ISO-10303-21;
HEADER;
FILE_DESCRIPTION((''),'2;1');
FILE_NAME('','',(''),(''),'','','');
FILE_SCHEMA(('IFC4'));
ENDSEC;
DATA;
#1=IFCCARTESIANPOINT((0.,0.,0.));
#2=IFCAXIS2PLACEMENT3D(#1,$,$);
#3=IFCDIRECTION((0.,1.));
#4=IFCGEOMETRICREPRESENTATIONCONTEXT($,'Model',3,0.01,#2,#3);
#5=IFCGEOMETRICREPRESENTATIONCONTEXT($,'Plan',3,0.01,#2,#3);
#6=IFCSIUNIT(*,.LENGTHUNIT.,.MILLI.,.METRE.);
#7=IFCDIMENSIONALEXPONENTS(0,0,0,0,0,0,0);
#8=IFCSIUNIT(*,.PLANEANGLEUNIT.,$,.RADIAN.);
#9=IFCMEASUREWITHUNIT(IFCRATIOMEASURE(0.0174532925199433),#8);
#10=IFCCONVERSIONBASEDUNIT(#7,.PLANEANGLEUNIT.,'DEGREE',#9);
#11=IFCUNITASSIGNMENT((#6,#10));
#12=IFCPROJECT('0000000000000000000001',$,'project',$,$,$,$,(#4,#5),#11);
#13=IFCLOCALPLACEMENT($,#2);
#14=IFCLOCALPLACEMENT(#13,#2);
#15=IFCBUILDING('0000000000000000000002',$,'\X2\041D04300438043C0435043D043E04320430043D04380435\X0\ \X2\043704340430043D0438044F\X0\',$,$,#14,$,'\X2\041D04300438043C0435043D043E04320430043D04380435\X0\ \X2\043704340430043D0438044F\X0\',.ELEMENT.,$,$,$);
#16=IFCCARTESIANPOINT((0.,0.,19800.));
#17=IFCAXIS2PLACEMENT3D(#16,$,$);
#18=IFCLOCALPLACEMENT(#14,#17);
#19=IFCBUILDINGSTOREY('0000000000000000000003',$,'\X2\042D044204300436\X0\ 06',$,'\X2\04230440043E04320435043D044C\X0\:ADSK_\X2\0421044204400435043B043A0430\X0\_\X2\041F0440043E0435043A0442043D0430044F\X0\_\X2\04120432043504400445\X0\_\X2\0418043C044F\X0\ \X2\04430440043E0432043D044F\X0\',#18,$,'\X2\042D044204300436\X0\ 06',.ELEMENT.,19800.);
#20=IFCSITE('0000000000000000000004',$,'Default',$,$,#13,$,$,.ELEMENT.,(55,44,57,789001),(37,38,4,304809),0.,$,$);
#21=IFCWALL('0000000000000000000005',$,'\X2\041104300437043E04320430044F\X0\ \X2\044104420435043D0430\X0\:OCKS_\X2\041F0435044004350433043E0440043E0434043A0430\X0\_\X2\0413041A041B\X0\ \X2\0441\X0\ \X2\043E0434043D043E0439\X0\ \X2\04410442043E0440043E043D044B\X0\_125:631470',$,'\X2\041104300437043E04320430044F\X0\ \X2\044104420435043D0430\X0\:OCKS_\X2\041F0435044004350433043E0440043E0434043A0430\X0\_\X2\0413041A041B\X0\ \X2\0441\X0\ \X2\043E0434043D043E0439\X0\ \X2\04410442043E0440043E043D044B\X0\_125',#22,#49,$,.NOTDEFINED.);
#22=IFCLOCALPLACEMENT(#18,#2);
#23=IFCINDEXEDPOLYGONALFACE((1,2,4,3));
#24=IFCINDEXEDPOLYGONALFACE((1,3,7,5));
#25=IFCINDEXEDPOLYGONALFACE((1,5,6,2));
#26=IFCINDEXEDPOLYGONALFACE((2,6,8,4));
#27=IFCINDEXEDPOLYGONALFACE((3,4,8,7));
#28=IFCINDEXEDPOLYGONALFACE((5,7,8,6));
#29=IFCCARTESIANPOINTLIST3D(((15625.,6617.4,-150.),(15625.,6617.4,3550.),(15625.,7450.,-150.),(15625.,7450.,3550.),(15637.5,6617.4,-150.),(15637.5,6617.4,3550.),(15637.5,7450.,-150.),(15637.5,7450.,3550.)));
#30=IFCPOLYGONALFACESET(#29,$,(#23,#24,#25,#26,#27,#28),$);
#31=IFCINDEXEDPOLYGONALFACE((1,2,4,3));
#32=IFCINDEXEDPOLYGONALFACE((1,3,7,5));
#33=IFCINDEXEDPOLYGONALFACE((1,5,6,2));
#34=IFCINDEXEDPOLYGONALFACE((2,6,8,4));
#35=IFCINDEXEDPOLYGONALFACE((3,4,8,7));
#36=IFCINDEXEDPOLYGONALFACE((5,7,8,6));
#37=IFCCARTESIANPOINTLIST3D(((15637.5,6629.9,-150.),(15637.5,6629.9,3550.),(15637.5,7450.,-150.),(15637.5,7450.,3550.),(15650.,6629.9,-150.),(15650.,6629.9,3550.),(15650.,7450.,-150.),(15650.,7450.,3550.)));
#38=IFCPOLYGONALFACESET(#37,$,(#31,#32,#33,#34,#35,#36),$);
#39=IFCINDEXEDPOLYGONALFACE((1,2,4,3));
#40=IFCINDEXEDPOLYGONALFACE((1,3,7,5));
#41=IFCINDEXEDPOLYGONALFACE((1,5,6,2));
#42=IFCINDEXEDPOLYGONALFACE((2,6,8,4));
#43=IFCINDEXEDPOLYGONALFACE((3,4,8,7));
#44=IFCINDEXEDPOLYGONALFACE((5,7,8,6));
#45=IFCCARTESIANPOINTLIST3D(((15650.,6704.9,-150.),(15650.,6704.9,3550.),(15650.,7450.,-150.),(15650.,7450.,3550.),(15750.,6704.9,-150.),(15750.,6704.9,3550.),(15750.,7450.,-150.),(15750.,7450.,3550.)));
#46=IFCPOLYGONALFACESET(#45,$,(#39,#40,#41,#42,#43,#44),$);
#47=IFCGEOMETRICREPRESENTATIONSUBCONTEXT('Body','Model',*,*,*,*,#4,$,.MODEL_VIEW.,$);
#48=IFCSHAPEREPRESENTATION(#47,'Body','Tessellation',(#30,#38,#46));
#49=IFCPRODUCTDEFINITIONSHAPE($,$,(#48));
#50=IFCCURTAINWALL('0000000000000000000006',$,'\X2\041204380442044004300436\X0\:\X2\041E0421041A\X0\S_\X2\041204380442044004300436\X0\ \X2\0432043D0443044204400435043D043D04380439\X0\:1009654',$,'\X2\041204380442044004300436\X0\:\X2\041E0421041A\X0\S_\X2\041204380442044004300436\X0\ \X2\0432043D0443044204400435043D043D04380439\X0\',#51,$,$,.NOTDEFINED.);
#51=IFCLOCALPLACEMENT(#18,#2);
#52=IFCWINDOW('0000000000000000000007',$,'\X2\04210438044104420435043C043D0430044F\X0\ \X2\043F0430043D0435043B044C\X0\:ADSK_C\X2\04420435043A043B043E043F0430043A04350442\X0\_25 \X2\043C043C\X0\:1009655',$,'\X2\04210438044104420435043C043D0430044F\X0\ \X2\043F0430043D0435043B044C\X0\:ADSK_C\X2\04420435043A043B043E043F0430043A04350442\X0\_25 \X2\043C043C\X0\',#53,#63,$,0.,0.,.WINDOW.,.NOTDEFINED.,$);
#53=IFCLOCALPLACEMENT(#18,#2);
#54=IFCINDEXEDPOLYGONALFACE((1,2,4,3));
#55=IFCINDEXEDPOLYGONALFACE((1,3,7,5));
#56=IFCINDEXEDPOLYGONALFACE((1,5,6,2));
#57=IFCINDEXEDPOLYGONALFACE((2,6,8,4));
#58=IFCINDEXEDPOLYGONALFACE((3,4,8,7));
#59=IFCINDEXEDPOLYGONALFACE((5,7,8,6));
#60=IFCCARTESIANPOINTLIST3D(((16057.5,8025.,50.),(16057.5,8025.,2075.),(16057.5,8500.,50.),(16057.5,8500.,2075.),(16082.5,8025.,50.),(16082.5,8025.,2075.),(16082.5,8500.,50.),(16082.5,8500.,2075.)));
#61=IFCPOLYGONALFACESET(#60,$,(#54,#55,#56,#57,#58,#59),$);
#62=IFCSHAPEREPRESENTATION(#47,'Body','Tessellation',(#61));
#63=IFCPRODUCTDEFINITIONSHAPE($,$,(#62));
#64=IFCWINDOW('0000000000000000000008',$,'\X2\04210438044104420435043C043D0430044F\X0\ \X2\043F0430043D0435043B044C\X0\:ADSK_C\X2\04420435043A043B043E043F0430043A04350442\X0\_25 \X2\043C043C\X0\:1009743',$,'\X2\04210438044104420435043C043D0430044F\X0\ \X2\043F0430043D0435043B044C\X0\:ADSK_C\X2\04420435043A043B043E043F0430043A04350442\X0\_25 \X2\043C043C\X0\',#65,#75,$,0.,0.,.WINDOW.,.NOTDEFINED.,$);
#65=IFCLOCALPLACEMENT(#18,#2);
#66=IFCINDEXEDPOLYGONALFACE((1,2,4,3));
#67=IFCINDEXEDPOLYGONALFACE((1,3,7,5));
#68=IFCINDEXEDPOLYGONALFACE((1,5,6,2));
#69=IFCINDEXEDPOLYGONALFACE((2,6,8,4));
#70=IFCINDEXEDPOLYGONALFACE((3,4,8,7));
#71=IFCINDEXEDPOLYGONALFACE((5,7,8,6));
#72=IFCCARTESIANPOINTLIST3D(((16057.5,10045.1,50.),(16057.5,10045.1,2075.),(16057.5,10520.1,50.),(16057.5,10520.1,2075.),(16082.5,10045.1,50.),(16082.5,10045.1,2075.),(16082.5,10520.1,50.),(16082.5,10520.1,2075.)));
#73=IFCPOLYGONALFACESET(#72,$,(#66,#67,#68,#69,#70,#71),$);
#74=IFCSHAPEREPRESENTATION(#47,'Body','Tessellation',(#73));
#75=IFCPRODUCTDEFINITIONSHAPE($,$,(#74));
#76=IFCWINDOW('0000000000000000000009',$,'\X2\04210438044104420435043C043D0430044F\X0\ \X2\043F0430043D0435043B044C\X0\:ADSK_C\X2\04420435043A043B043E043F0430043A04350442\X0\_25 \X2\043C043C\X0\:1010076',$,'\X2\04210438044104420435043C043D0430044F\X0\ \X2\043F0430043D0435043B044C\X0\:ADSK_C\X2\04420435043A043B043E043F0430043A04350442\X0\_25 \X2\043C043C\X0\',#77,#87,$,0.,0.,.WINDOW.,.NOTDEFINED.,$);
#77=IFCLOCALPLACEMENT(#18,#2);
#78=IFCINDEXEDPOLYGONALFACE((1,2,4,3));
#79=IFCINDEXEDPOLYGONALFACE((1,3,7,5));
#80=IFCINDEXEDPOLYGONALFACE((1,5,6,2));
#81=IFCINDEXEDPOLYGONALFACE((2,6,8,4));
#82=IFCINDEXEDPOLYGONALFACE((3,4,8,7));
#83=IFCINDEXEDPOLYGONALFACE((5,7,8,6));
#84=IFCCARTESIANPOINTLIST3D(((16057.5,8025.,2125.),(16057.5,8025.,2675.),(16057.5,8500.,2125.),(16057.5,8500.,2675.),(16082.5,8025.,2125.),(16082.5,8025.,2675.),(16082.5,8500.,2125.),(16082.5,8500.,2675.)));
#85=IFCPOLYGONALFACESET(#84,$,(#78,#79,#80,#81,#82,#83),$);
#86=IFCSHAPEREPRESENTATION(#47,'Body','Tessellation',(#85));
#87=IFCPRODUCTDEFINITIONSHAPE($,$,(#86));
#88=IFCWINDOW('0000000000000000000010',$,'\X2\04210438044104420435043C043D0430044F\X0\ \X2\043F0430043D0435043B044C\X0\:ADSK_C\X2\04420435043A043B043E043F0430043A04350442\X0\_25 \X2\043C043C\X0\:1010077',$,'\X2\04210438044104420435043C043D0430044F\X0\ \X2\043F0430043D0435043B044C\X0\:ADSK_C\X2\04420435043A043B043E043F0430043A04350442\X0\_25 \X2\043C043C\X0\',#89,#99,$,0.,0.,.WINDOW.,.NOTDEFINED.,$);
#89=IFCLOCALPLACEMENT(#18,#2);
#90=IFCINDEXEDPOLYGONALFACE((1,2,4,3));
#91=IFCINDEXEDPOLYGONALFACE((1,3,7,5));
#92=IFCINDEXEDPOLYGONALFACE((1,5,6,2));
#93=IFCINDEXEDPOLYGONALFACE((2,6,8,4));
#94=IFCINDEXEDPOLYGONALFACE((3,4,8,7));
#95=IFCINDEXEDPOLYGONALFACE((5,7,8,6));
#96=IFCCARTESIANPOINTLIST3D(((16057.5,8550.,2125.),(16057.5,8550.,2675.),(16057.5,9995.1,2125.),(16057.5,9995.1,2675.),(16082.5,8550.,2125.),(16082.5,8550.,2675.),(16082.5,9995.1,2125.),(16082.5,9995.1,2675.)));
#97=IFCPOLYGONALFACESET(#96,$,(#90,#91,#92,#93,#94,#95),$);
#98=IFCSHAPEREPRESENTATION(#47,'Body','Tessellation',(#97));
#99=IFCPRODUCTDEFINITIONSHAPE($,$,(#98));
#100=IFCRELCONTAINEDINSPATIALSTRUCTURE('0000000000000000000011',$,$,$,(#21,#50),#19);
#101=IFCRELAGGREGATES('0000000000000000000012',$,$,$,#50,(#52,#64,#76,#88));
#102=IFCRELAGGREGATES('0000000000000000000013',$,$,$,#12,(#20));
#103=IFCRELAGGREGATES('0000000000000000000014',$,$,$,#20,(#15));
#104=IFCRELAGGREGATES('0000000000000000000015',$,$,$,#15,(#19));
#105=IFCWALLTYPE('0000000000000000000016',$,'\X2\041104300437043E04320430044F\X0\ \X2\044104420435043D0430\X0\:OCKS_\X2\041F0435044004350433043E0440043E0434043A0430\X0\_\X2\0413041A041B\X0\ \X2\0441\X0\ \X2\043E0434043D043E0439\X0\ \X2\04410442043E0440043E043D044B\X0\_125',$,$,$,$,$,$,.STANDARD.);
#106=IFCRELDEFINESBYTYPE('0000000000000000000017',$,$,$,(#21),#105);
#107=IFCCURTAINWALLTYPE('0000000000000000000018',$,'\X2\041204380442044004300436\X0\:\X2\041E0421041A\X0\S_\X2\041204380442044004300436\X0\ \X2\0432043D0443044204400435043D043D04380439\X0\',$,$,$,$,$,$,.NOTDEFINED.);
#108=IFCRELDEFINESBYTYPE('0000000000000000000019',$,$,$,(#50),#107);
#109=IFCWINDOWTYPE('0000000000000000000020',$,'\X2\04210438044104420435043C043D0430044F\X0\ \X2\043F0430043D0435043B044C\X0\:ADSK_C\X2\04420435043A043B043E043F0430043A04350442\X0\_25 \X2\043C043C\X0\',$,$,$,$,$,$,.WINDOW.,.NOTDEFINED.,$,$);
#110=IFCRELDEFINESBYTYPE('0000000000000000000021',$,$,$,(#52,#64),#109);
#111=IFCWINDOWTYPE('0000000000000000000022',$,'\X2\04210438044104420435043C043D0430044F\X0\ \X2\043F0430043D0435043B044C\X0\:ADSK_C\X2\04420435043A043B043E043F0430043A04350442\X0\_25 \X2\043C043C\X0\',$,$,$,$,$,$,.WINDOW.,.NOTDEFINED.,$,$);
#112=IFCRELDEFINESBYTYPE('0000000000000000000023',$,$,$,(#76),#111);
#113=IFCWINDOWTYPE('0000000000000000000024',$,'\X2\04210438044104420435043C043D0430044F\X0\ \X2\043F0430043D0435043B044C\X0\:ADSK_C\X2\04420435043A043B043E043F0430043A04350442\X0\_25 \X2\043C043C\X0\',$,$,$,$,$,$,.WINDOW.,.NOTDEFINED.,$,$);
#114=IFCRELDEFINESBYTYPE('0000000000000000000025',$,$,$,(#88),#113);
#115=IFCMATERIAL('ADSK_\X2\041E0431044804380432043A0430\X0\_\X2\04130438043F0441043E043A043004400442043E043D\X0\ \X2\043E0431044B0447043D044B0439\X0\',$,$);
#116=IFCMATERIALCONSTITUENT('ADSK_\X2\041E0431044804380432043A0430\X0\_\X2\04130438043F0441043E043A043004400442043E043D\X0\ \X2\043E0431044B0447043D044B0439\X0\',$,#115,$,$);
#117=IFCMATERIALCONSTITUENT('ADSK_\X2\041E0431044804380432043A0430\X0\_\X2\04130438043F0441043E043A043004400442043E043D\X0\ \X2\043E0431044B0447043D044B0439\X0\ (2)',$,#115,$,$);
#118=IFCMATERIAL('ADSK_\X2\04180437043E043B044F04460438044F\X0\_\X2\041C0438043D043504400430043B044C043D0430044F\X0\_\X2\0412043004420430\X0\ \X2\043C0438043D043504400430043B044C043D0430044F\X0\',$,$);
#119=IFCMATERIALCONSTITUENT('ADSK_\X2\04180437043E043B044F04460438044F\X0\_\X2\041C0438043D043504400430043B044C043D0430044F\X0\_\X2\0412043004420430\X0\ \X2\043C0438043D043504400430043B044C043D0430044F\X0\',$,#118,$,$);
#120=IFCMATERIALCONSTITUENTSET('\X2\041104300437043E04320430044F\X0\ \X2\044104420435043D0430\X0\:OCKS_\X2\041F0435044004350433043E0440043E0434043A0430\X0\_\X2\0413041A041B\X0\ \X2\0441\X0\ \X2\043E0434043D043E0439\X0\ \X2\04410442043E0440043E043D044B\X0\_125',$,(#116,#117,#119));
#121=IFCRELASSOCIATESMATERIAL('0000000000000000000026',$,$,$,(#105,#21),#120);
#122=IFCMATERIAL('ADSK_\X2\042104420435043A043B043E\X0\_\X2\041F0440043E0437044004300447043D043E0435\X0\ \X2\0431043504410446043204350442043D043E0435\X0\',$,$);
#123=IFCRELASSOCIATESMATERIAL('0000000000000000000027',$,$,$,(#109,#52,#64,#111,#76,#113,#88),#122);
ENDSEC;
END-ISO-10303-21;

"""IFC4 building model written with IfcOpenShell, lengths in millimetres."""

from ifc_helpers import new_model, entity, si_unit, converted_unit, direction, frame, origin, place, context, subcontext, project, spatial, indexed_curve, outline, extrude, source, transform, mapped, material, constituent, constituent_set, type_object, type_shapes, element, aggregate, save


model = new_model("IFC4")

# Units and contexts
model_context = context("Model", 3, precision=0.01, world=origin(), true_north=direction((0.0, 1.0)))
plan_context = context("Plan", 3, precision=0.01, world=origin(), true_north=direction((0.0, 1.0)))
body_context = subcontext(model_context, "Body", "Model", "MODEL_VIEW")
ifc_project = project(units=[si_unit("LENGTHUNIT", "METRE", prefix="MILLI"), converted_unit("PLANEANGLEUNIT", "DEGREE", entity("IfcRatioMeasure", 0.0174532925199433), si_unit("PLANEANGLEUNIT", "RADIAN"), dimensions=[0, 0, 0, 0, 0, 0, 0])], contexts=[model_context, plan_context])

# Site, building, storey
site_placement = place(None, frame((0.0, 0.0, 0.0)))
site = spatial("IfcSite", under=ifc_project, at=site_placement, Name="Default", CompositionType="ELEMENT", RefLatitude=(55, 44, 57, 789001), RefLongitude=(37, 38, 4, 304809), RefElevation=0.0)
building_placement = place(site_placement, origin())
building = spatial("IfcBuilding", under=site, at=building_placement, Name="Наименование здания", LongName="Наименование здания", CompositionType="ELEMENT")
storey_placement = place(building_placement, frame((0.0, 0.0, 19800.0)))
storey = spatial("IfcBuildingStorey", under=building, at=storey_placement, Name="Этаж 06", ObjectType="Уровень:ADSK_Стрелка_Проектная_Вверх_Имя уровня", LongName="Этаж 06", CompositionType="ELEMENT", Elevation=19800.0)

# Shared definitions
ifc_material_1 = material(Name="ADSK_Обшивка_Гипсокартон обычный")
ifc_material_2 = material(Name="ADSK_Изоляция_Минеральная_Вата минеральная")

# Wall
ifc_constituent_1 = constituent(ifc_material_1, Name="ADSK_Обшивка_Гипсокартон обычный")
ifc_constituent_2 = constituent(ifc_material_1, Name="ADSK_Обшивка_Гипсокартон обычный (2)")
ifc_constituent_3 = constituent(ifc_material_2, Name="ADSK_Изоляция_Минеральная_Вата минеральная")
ifc_constituent_set_1 = constituent_set(constituents=[ifc_constituent_1, ifc_constituent_2, ifc_constituent_3], Name="Базовая стена:OCKS_Перегородка_ГКЛ с одной стороны_125")
wall_type_1 = type_object("IfcWallType", Name="Базовая стена:OCKS_Перегородка_ГКЛ с одной стороны_125", PredefinedType="STANDARD", material=ifc_constituent_set_1)
wall_1_placement = place(storey_placement, frame((15687.5, 6729.9, -150.0), z_axis=(0.0, 0.0, 1.0), x_axis=(0.0, 1.0, 0.0)))
element("IfcWall", 1, at=wall_1_placement, inside=storey, type_object=wall_type_1, material=ifc_constituent_set_1, Name="Базовая стена:OCKS_Перегородка_ГКЛ с одной стороны_125:631470", ObjectType="Базовая стена:OCKS_Перегородка_ГКЛ с одной стороны_125", PredefinedType="NOTDEFINED", context=body_context, shape_type="SweptSolid", body=[
    extrude(outline(indexed_curve([(-6.3, -416.3), (6.3, -416.3), (6.3, 416.3), (-6.2, 416.3), (-6.3, -416.3)], self_intersect=False)), frame((303.8, 56.3, 0.0), z_axis=(0.0, 0.0, 1.0), x_axis=(0.0, -1.0, 0.0)), (0.0, 0.0, 1.0), 3700.0),
    extrude(outline(indexed_curve([(-410.0, -6.2), (410.0, -6.2), (410.0, 6.3), (-410.0, 6.3), (-410.0, -6.2)], self_intersect=False)), frame((310.0, 43.7, 0.0)), (0.0, 0.0, 1.0), 3700.0),
    extrude(outline(indexed_curve([(-50.0, -372.5), (50.0, -372.5), (50.0, 372.5), (-50.0, 372.5), (-50.0, -372.5)], self_intersect=False)), frame((347.5, -12.5, 0.0), z_axis=(0.0, 0.0, 1.0), x_axis=(0.0, 1.0, 0.0)), (0.0, 0.0, 1.0), 3700.0),
])

# Curtain wall, windows
curtain_wall_type = type_object("IfcCurtainWallType", Name="Витраж:ОСКS_Витраж внутренний", PredefinedType="NOTDEFINED")
curtain_wall_placement = place(storey_placement, frame((0.0, 0.0, -19800.0)))
curtain_wall = element("IfcCurtainWall", 2, at=curtain_wall_placement, inside=storey, type_object=curtain_wall_type, Name="Витраж:ОСКS_Витраж внутренний:1009654", ObjectType="Витраж:ОСКS_Витраж внутренний", PredefinedType="NOTDEFINED")
ifc_material_3 = material(Name="ADSK_Стекло_Прозрачное бесцветное")
window_type_1 = type_object("IfcWindowType", Name="Системная панель:ADSK_Cтеклопакет_25 мм", PartitioningType="NOTDEFINED", PredefinedType="WINDOW", material=ifc_material_3)
shared_shape_1 = source(origin(), body_context, "Body", "SweptSolid", [
    extrude(outline(indexed_curve([(-12.5, -237.5), (12.5, -237.5), (12.5, 237.5), (-12.5, 237.5), (-12.5, -237.5)], self_intersect=False)), frame((0.0, 0.0, 0.0), z_axis=(0.0, 0.0, 1.0), x_axis=(0.0, 1.0, 0.0)), (0.0, 0.0, 1.0), 2025.0),
])
type_shapes(window_type_1, [shared_shape_1])
window_1_placement = place(curtain_wall_placement, frame((16070.0, 8262.5, 19850.0), z_axis=(0.0, 0.0, 1.0), x_axis=(0.0, 1.0, 0.0)))
window_1 = element("IfcWindow", 3, at=window_1_placement, type_object=window_type_1, material=ifc_material_3, Name="Системная панель:ADSK_Cтеклопакет_25 мм:1009655", ObjectType="Системная панель:ADSK_Cтеклопакет_25 мм", OverallHeight=0.0, OverallWidth=0.0, PartitioningType="NOTDEFINED", PredefinedType="WINDOW", context=body_context, shape_type="MappedRepresentation", body=[
    mapped(shared_shape_1, transform((0.0, 0.0, 0.0), scale=1.0)),
])
window_2_placement = place(curtain_wall_placement, frame((16070.0, 10282.6, 19850.0), z_axis=(0.0, 0.0, 1.0), x_axis=(0.0, 1.0, 0.0)))
window_2 = element("IfcWindow", 4, at=window_2_placement, type_object=window_type_1, material=ifc_material_3, Name="Системная панель:ADSK_Cтеклопакет_25 мм:1009743", ObjectType="Системная панель:ADSK_Cтеклопакет_25 мм", OverallHeight=0.0, OverallWidth=0.0, PartitioningType="NOTDEFINED", PredefinedType="WINDOW", context=body_context, shape_type="MappedRepresentation", body=[
    mapped(shared_shape_1, transform((0.0, 0.0, 0.0), scale=1.0)),
])
window_type_2 = type_object("IfcWindowType", Name="Системная панель:ADSK_Cтеклопакет_25 мм", PartitioningType="NOTDEFINED", PredefinedType="WINDOW", material=ifc_material_3)
shared_shape_2 = source(origin(), body_context, "Body", "SweptSolid", [
    extrude(outline(indexed_curve([(-12.5, -237.5), (12.5, -237.5), (12.5, 237.5), (-12.5, 237.5), (-12.5, -237.5)], self_intersect=False)), frame((0.0, 0.0, 0.0), z_axis=(0.0, 0.0, 1.0), x_axis=(0.0, 1.0, 0.0)), (0.0, 0.0, 1.0), 550.0),
])
type_shapes(window_type_2, [shared_shape_2])
window_3_placement = place(curtain_wall_placement, frame((16070.0, 8262.5, 21925.0), z_axis=(0.0, 0.0, 1.0), x_axis=(0.0, 1.0, 0.0)))
window_3 = element("IfcWindow", 5, at=window_3_placement, type_object=window_type_2, material=ifc_material_3, Name="Системная панель:ADSK_Cтеклопакет_25 мм:1010076", ObjectType="Системная панель:ADSK_Cтеклопакет_25 мм", OverallHeight=0.0, OverallWidth=0.0, PartitioningType="NOTDEFINED", PredefinedType="WINDOW", context=body_context, shape_type="MappedRepresentation", body=[
    mapped(shared_shape_2, transform((0.0, 0.0, 0.0), scale=1.0)),
])
window_type_3 = type_object("IfcWindowType", Name="Системная панель:ADSK_Cтеклопакет_25 мм", PartitioningType="NOTDEFINED", PredefinedType="WINDOW", material=ifc_material_3)
shared_shape_3 = source(origin(), body_context, "Body", "SweptSolid", [
    extrude(outline(indexed_curve([(-12.5, -722.6), (12.5, -722.6), (12.5, 722.6), (-12.5, 722.6), (-12.5, -722.6)], self_intersect=False)), frame((0.0, 0.0, 0.0), z_axis=(0.0, 0.0, 1.0), x_axis=(0.0, 1.0, 0.0)), (0.0, 0.0, 1.0), 550.0),
])
type_shapes(window_type_3, [shared_shape_3])
window_4_placement = place(curtain_wall_placement, frame((16070.0, 9272.6, 21925.0), z_axis=(0.0, 0.0, 1.0), x_axis=(0.0, 1.0, 0.0)))
window_4 = element("IfcWindow", 6, at=window_4_placement, type_object=window_type_3, material=ifc_material_3, Name="Системная панель:ADSK_Cтеклопакет_25 мм:1010077", ObjectType="Системная панель:ADSK_Cтеклопакет_25 мм", OverallHeight=0.0, OverallWidth=0.0, PartitioningType="NOTDEFINED", PredefinedType="WINDOW", context=body_context, shape_type="MappedRepresentation", body=[
    mapped(shared_shape_3, transform((0.0, 0.0, 0.0), scale=1.0)),
])
aggregate(curtain_wall, [window_1, window_2, window_3, window_4])

save(model, "model.ifc")
